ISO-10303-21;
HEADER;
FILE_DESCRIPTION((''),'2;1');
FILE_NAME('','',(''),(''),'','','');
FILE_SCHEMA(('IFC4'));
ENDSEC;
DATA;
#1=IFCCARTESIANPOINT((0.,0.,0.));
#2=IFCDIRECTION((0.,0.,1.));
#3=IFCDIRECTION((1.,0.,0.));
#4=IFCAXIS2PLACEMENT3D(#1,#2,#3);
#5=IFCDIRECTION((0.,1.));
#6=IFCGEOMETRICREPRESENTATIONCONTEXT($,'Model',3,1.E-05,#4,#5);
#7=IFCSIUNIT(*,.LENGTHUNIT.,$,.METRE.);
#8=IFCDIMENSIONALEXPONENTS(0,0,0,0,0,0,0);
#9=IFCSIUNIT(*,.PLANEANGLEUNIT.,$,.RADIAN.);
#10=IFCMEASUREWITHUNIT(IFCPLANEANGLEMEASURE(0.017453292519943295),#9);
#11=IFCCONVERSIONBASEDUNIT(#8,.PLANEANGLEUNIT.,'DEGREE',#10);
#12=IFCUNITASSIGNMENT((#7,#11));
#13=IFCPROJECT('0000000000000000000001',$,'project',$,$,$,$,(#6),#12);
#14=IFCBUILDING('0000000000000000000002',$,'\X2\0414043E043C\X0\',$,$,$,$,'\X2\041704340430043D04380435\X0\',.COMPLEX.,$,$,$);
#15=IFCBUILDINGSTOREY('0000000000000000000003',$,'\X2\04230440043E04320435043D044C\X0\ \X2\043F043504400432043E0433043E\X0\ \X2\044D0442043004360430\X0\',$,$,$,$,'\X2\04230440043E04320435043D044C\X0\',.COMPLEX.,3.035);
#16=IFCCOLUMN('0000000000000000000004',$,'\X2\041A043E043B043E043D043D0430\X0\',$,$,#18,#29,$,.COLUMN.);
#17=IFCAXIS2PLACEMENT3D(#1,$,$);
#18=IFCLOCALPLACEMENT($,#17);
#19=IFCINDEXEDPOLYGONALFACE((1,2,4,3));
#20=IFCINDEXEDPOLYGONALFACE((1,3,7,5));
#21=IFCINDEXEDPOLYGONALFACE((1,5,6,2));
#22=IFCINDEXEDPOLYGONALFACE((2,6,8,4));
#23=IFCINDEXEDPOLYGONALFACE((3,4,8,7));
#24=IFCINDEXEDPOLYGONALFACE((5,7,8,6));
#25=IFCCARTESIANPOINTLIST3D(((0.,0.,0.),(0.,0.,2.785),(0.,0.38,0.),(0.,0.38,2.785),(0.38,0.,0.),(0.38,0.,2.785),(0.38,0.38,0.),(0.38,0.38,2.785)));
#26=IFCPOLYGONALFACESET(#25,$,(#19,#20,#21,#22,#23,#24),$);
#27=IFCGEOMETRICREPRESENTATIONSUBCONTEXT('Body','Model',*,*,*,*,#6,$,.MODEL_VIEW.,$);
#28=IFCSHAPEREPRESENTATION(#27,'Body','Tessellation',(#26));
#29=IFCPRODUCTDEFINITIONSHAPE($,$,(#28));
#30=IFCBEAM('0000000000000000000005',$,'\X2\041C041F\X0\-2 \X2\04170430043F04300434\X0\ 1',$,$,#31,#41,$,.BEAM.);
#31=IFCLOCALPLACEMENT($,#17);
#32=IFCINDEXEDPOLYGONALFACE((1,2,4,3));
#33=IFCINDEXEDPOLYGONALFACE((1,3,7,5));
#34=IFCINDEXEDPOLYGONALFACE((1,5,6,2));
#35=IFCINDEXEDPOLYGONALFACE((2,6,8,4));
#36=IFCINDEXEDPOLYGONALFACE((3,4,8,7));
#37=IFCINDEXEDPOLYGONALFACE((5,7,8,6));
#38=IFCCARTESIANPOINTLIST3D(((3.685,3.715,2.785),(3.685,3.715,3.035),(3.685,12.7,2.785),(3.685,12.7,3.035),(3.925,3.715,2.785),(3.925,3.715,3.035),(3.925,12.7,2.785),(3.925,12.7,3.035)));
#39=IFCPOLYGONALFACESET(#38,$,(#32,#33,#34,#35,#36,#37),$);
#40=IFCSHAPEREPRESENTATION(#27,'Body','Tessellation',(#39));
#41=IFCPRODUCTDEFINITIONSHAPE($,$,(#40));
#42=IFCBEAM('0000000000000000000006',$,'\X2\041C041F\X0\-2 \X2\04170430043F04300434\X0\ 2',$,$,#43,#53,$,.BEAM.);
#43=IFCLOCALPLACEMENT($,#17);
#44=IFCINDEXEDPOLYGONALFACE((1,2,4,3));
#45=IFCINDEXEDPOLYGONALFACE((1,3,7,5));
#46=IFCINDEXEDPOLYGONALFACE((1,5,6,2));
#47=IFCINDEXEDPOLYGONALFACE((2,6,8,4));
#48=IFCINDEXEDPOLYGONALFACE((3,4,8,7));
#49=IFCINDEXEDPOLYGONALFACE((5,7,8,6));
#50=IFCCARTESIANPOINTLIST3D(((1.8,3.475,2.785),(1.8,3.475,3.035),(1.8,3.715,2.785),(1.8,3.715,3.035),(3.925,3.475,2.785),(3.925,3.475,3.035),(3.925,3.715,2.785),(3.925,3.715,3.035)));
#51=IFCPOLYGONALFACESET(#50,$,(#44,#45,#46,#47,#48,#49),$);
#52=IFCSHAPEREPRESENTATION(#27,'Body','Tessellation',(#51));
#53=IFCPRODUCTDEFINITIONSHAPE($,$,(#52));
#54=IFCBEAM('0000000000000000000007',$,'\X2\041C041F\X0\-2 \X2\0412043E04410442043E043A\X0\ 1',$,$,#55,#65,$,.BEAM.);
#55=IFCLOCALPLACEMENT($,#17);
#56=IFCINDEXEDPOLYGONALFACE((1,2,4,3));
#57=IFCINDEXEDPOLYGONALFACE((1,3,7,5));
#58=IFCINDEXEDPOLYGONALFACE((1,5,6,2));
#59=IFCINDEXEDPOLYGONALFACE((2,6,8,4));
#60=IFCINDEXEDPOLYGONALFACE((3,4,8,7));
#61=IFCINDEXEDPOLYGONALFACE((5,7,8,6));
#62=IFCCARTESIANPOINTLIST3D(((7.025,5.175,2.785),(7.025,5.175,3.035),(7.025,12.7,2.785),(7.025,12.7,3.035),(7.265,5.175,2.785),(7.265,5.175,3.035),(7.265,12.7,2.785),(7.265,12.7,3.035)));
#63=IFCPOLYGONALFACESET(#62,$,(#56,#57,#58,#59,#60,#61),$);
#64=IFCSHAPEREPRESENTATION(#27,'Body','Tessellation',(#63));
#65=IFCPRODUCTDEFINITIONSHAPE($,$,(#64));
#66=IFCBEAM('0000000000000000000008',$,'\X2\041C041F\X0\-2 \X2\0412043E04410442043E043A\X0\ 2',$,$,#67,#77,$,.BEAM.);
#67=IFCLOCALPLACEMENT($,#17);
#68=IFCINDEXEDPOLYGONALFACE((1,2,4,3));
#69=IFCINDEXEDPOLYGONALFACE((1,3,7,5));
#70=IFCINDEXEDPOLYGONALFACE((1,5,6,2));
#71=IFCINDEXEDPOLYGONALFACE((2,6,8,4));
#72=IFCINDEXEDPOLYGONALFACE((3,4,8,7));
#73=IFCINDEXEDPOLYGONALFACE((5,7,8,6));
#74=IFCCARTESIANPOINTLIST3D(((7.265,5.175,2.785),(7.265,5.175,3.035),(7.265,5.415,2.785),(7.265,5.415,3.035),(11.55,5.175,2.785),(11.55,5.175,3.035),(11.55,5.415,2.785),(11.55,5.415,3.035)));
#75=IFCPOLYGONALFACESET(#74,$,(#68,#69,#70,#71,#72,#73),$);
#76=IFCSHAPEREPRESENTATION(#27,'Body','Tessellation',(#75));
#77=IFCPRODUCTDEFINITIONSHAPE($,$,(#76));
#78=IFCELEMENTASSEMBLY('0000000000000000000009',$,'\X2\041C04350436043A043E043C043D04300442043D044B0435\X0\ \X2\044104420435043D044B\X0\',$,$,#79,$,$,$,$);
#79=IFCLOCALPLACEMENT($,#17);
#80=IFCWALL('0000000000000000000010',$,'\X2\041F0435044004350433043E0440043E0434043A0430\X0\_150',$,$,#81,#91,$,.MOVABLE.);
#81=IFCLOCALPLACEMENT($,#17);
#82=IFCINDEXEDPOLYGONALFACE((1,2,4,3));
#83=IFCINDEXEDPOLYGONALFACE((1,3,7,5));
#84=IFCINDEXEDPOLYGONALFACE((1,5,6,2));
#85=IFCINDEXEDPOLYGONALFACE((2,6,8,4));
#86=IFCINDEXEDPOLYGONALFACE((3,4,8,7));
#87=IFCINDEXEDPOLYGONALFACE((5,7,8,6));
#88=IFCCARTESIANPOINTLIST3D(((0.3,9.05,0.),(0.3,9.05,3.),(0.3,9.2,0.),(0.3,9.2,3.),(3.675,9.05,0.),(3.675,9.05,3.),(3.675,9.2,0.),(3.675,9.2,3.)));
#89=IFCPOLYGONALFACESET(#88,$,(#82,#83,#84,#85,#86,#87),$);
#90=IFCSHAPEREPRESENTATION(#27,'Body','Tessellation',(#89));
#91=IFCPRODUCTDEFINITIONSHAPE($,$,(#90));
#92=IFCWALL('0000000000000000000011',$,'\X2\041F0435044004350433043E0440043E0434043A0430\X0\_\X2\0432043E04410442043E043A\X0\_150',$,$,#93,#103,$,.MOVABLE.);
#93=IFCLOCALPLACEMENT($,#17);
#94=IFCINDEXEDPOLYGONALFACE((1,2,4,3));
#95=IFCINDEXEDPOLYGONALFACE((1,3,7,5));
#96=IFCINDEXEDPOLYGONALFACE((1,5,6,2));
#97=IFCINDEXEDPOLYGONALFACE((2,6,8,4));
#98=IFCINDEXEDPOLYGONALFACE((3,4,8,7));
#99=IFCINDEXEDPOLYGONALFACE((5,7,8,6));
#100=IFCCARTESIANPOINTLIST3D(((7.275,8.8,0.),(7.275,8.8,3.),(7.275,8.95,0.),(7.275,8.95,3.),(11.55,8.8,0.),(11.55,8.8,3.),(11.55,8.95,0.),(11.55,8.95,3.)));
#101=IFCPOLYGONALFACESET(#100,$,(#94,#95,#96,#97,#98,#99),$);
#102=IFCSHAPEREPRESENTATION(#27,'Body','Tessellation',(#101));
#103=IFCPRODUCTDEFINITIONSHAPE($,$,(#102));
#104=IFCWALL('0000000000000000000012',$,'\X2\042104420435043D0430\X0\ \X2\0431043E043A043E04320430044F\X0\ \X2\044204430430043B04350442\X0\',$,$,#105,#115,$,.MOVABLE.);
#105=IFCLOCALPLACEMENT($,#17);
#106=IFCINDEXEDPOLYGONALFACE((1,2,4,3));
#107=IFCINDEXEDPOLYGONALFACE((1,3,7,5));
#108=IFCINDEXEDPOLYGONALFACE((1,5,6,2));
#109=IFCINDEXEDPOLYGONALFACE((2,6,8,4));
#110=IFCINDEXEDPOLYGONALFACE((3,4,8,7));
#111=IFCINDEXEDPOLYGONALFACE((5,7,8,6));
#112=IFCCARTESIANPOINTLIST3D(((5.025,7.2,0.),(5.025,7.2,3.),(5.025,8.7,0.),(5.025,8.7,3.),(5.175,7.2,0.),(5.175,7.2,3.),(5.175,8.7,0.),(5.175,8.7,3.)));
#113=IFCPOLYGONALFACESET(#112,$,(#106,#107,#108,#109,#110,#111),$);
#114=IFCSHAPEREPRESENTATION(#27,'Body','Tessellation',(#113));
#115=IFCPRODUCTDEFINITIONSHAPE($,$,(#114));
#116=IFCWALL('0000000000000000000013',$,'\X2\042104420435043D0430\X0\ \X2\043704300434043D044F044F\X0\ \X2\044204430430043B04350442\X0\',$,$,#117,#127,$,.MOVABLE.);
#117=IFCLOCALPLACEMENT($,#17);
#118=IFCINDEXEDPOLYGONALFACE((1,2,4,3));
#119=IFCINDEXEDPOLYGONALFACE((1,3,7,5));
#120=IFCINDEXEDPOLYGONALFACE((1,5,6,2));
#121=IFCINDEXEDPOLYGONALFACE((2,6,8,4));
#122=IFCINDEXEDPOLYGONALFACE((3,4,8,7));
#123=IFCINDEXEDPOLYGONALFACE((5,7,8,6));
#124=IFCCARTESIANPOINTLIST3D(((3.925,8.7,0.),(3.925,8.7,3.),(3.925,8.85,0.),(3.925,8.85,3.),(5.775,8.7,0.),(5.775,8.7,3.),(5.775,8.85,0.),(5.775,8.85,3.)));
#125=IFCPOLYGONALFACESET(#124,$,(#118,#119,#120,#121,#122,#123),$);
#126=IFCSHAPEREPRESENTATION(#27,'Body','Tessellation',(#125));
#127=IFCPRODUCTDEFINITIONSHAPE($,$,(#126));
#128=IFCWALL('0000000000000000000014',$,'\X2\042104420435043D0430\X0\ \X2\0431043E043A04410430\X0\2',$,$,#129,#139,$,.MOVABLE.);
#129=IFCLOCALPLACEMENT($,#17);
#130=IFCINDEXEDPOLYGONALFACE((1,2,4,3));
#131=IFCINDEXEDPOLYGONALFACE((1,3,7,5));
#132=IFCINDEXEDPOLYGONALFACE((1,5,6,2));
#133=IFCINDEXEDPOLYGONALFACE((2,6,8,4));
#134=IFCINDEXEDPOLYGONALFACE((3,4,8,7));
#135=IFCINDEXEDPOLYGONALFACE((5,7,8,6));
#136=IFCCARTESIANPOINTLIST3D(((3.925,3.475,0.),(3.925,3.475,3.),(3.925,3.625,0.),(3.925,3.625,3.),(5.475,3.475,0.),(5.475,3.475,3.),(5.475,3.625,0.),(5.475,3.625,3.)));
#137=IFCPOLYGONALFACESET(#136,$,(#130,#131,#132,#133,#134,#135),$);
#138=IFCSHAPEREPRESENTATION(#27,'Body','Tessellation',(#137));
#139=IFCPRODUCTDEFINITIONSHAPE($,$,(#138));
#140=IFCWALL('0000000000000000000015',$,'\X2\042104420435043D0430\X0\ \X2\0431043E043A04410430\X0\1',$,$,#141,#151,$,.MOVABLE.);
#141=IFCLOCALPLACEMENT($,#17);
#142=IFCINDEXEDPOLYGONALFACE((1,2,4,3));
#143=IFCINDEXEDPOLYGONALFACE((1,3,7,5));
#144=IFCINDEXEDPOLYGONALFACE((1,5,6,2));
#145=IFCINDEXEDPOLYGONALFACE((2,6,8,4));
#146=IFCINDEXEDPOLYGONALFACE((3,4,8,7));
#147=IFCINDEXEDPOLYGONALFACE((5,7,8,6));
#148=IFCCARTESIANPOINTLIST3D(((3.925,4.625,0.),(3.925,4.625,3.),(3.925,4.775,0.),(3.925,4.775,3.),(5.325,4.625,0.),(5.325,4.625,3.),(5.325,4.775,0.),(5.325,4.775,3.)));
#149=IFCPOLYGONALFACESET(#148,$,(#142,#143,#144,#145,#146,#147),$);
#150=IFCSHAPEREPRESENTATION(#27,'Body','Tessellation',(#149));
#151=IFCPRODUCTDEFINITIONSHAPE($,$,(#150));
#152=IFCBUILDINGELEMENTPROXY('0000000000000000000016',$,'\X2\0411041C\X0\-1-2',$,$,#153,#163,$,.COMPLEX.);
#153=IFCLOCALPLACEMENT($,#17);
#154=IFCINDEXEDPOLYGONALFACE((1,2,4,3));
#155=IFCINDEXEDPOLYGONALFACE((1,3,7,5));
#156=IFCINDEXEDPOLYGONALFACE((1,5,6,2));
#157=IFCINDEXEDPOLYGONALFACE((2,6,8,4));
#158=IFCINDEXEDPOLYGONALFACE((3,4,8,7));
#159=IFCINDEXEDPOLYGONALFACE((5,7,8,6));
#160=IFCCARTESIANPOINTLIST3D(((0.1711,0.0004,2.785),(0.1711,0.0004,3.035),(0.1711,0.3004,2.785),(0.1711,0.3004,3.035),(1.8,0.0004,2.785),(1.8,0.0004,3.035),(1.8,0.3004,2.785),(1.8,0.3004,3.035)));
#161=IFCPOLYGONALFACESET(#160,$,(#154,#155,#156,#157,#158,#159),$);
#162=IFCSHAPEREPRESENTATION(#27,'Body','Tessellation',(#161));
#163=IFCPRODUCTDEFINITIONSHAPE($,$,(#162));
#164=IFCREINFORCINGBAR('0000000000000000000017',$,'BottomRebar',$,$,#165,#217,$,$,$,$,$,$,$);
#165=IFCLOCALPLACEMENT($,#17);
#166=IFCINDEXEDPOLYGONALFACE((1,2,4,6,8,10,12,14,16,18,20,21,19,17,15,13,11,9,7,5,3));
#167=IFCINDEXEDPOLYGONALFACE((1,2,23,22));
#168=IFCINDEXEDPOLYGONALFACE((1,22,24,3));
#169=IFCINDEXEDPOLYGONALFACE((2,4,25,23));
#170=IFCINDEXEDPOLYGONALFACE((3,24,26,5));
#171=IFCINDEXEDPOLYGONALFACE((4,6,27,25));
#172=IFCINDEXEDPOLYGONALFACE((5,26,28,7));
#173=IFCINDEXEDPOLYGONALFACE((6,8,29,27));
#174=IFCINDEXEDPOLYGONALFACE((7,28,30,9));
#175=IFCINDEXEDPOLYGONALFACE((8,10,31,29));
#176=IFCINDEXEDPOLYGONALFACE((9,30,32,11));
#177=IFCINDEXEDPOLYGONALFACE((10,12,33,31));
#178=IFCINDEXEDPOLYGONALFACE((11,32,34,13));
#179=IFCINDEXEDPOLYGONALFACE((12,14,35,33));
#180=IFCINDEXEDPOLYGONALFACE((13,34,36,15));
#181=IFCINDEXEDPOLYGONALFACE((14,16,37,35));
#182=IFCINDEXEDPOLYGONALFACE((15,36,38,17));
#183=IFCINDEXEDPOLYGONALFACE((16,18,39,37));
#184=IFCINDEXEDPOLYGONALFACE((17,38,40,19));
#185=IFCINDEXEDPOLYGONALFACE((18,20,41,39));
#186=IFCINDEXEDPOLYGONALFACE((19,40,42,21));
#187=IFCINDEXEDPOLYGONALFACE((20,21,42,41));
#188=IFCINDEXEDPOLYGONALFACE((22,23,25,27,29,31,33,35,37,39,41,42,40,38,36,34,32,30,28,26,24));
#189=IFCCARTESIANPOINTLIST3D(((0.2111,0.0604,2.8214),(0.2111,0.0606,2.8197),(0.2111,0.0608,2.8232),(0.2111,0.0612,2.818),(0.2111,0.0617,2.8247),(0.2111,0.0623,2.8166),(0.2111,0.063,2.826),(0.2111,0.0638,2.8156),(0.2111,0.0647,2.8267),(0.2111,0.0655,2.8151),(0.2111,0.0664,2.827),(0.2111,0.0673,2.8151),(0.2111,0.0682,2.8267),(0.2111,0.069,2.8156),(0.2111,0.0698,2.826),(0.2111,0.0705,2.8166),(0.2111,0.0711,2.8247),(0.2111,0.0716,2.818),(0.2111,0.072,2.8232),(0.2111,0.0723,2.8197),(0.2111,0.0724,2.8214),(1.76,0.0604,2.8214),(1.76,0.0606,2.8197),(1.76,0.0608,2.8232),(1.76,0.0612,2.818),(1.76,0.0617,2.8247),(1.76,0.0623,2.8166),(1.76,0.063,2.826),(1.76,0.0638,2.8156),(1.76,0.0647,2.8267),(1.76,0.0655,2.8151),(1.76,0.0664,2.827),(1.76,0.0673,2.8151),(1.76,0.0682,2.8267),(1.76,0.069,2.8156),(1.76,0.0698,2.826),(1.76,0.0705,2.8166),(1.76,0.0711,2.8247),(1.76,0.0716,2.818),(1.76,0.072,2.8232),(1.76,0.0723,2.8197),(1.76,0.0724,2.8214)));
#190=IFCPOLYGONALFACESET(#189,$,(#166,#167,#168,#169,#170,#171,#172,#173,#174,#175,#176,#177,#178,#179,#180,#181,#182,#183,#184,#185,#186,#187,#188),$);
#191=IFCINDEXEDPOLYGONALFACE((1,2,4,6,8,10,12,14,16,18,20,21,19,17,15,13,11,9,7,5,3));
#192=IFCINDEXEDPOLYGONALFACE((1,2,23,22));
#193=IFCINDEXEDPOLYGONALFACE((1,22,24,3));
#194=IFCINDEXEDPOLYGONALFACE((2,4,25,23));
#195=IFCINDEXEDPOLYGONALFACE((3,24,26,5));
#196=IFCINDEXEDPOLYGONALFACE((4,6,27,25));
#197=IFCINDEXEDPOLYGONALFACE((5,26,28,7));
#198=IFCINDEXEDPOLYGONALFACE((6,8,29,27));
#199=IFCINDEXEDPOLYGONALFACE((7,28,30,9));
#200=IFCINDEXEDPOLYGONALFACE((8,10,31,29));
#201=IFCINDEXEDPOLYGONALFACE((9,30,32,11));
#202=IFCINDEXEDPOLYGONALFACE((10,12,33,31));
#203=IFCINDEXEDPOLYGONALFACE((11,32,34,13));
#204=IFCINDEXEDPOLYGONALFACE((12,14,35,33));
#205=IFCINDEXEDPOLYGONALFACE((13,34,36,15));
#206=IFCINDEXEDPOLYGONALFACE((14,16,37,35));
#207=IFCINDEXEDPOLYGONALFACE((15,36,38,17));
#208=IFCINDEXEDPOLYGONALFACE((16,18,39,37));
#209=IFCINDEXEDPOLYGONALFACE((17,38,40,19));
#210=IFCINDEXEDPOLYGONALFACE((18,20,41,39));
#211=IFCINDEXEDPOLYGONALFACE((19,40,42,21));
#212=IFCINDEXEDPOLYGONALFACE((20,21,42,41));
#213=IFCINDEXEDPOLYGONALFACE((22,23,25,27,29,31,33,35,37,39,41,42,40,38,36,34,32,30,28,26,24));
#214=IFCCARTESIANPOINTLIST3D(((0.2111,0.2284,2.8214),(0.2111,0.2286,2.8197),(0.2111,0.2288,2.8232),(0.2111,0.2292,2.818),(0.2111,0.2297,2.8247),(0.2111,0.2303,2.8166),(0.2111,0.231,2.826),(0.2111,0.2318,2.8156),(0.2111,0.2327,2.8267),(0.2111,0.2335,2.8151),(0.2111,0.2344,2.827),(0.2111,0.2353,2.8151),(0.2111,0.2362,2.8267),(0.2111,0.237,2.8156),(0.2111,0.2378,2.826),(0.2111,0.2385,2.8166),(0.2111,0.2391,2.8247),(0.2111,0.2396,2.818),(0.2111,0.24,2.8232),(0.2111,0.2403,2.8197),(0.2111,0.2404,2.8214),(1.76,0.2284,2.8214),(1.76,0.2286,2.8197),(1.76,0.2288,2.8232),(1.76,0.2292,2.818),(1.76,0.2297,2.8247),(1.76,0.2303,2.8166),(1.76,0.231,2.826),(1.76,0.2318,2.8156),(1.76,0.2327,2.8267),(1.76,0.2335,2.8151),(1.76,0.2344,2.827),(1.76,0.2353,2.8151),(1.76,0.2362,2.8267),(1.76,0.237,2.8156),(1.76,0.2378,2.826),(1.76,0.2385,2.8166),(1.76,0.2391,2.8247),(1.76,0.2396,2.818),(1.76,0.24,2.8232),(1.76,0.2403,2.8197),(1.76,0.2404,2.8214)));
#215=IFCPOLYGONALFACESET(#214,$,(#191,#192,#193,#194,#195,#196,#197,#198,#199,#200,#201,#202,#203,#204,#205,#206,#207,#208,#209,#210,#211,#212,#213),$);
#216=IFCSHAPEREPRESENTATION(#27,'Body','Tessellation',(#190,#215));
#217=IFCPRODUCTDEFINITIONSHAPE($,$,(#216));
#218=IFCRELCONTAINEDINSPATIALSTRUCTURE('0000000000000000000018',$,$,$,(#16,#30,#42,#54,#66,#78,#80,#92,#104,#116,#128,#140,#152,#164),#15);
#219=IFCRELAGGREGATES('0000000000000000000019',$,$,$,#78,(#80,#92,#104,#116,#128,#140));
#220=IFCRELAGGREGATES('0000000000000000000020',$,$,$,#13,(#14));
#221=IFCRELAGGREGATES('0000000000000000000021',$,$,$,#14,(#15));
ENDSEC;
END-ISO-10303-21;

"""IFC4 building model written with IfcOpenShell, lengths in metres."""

from ifc_helpers import new_model, entity, si_unit, converted_unit, direction, frame, frame_2d, origin_with_axes, origin_2d_with_axis, place, context, subcontext, project, spatial, rectangle, extrude, element, aggregate, save


model = new_model("IFC4")

# Units and contexts
model_context = context("Model", 3, precision=1e-05, world=origin_with_axes(), true_north=direction((0.0, 1.0)))
body_context = subcontext(model_context, "Body", "Model", "MODEL_VIEW")
ifc_project = project(units=[si_unit("LENGTHUNIT", "METRE"), converted_unit("PLANEANGLEUNIT", "DEGREE", entity("IfcPlaneAngleMeasure", 0.017453292519943295), si_unit("PLANEANGLEUNIT", "RADIAN"), dimensions=[0, 0, 0, 0, 0, 0, 0])], contexts=[model_context])

# Building, storey
building = spatial("IfcBuilding", under=ifc_project, Name="Дом", LongName="Здание", CompositionType="COMPLEX")
storey = spatial("IfcBuildingStorey", under=building, Name="Уровень первого этажа", LongName="Уровень", CompositionType="COMPLEX", Elevation=3.035)

# Column
placement = place(None, origin_with_axes())
element("IfcColumn", 1, at=placement, inside=storey, Name="Колонна", PredefinedType="COLUMN", context=body_context, shape_type="SweptSolid", body=[
    extrude(rectangle(XDim=0.38, YDim=0.38, at=origin_2d_with_axis()), frame((0.19, 0.19, 0.0), z_axis=(0.0, 0.0, 1.0), x_axis=(1.0, 0.0, 0.0)), (0.0, 0.0, 1.0), 2.785),
])

# Beams
element("IfcBeam", 2, at=placement, inside=storey, Name="МП-2 Запад 1", PredefinedType="BEAM", context=body_context, shape_type="SweptSolid", body=[
    extrude(rectangle(XDim=0.24, YDim=8.985, at=origin_2d_with_axis()), frame((3.805, 8.2075, 2.785), z_axis=(0.0, 0.0, 1.0), x_axis=(1.0, 0.0, 0.0)), (0.0, 0.0, 1.0), 0.25),
])
element("IfcBeam", 3, at=placement, inside=storey, Name="МП-2 Запад 2", PredefinedType="BEAM", context=body_context, shape_type="SweptSolid", body=[
    extrude(rectangle(XDim=2.125, YDim=0.24, at=origin_2d_with_axis()), frame((2.8625, 3.595, 2.785), z_axis=(0.0, 0.0, 1.0), x_axis=(1.0, 0.0, 0.0)), (0.0, 0.0, 1.0), 0.25),
])
element("IfcBeam", 4, at=placement, inside=storey, Name="МП-2 Восток 1", PredefinedType="BEAM", context=body_context, shape_type="SweptSolid", body=[
    extrude(rectangle(XDim=0.24, YDim=7.525, at=origin_2d_with_axis()), frame((7.145, 8.9375, 2.785), z_axis=(0.0, 0.0, 1.0), x_axis=(1.0, 0.0, 0.0)), (0.0, 0.0, 1.0), 0.25),
])
element("IfcBeam", 5, at=placement, inside=storey, Name="МП-2 Восток 2", PredefinedType="BEAM", context=body_context, shape_type="SweptSolid", body=[
    extrude(rectangle(XDim=4.285, YDim=0.24, at=origin_2d_with_axis()), frame((9.4075, 5.295, 2.785), z_axis=(0.0, 0.0, 1.0), x_axis=(1.0, 0.0, 0.0)), (0.0, 0.0, 1.0), 0.25),
])

# Element assembly, walls
assembly_1 = element("IfcElementAssembly", 6, inside=storey, Name="Межкомнатные стены")
wall_1 = element("IfcWall", 7, at=placement, inside=storey, Name="Перегородка_150", PredefinedType="MOVABLE", context=body_context, shape_type="SweptSolid", body=[
    extrude(rectangle(XDim=3.375, YDim=0.15, at=origin_2d_with_axis()), frame((1.9875, 9.125, 0.0), z_axis=(0.0, 0.0, 1.0), x_axis=(1.0, 0.0, 0.0)), (0.0, 0.0, 1.0), 3.0),
])
wall_2 = element("IfcWall", 8, at=placement, inside=storey, Name="Перегородка_восток_150", PredefinedType="MOVABLE", context=body_context, shape_type="SweptSolid", body=[
    extrude(rectangle(XDim=4.275, YDim=0.15, at=frame_2d((0.0, 0.0), x_axis=(1.0, 0.0))), frame((9.4125, 8.875, 0.0), z_axis=(0.0, 0.0, 1.0), x_axis=(1.0, 0.0, 0.0)), (0.0, 0.0, 1.0), 3.0),
])
wall_3 = element("IfcWall", 9, at=placement, inside=storey, Name="Стена боковая туалет", PredefinedType="MOVABLE", context=body_context, shape_type="SweptSolid", body=[
    extrude(rectangle(XDim=1.5, YDim=0.15, at=frame_2d((0.0, 0.0), x_axis=(0.0, 1.0))), frame((5.1, 7.95, 0.0), z_axis=(0.0, 0.0, 1.0), x_axis=(1.0, 0.0, 0.0)), (0.0, 0.0, 1.0), 3.0),
])
wall_4 = element("IfcWall", 10, at=placement, inside=storey, Name="Стена задняя туалет", PredefinedType="MOVABLE", context=body_context, shape_type="SweptSolid", body=[
    extrude(rectangle(XDim=1.85, YDim=0.15, at=frame_2d((0.0, 0.0), x_axis=(1.0, 0.0))), frame((4.85, 8.775, 0.0), z_axis=(0.0, 0.0, 1.0), x_axis=(1.0, 0.0, 0.0)), (0.0, 0.0, 1.0), 3.0),
])
wall_5 = element("IfcWall", 11, at=placement, inside=storey, Name="Стена бокса2", PredefinedType="MOVABLE", context=body_context, shape_type="SweptSolid", body=[
    extrude(rectangle(XDim=1.55, YDim=0.15, at=frame_2d((0.0, 0.0), x_axis=(1.0, 0.0))), frame((4.7, 3.55, 0.0), z_axis=(0.0, 0.0, 1.0), x_axis=(1.0, 0.0, 0.0)), (0.0, 0.0, 1.0), 3.0),
])
wall_6 = element("IfcWall", 12, at=placement, inside=storey, Name="Стена бокса1", PredefinedType="MOVABLE", context=body_context, shape_type="SweptSolid", body=[
    extrude(rectangle(XDim=1.4, YDim=0.15, at=origin_2d_with_axis()), frame((4.625, 4.7, 0.0), z_axis=(0.0, 0.0, 1.0), x_axis=(1.0, 0.0, 0.0)), (0.0, 0.0, 1.0), 3.0),
])
aggregate(assembly_1, [wall_1, wall_2, wall_3, wall_4, wall_5, wall_6])

# Building element proxy
element("IfcBuildingElementProxy", 13, at=placement, inside=storey, Name="БМ-1-2", PredefinedType="COMPLEX", context=body_context, shape_type="SweptSolid", body=[
    extrude(rectangle(XDim=1.6289, YDim=0.3, at=origin_2d_with_axis()), frame((0.9855, 0.1504, 2.785), z_axis=(0.0, 0.0, 1.0), x_axis=(1.0, 0.0, 0.0)), (0.0, 0.0, 1.0), 0.25),
])

# Reinforcing bar
element("IfcReinforcingBar", 14, at=placement, inside=storey, Name="BottomRebar", context=body_context, shape_type="SweptSolid", body=[
    entity("IfcSweptDiskSolid", entity("IfcCompositeCurve", [entity("IfcCompositeCurveSegment", "CONTINUOUS", True, entity("IfcPolyline", [entity("IfcCartesianPoint", [0.2111, 0.0664, 2.821]), entity("IfcCartesianPoint", [1.76, 0.0664, 2.821])]))], False), 0.006),
    entity("IfcSweptDiskSolid", entity("IfcCompositeCurve", [entity("IfcCompositeCurveSegment", "CONTINUOUS", True, entity("IfcPolyline", [entity("IfcCartesianPoint", [0.2111, 0.2344, 2.821]), entity("IfcCartesianPoint", [1.76, 0.2344, 2.821])]))], False), 0.006),
])

save(model, "model.ifc")
